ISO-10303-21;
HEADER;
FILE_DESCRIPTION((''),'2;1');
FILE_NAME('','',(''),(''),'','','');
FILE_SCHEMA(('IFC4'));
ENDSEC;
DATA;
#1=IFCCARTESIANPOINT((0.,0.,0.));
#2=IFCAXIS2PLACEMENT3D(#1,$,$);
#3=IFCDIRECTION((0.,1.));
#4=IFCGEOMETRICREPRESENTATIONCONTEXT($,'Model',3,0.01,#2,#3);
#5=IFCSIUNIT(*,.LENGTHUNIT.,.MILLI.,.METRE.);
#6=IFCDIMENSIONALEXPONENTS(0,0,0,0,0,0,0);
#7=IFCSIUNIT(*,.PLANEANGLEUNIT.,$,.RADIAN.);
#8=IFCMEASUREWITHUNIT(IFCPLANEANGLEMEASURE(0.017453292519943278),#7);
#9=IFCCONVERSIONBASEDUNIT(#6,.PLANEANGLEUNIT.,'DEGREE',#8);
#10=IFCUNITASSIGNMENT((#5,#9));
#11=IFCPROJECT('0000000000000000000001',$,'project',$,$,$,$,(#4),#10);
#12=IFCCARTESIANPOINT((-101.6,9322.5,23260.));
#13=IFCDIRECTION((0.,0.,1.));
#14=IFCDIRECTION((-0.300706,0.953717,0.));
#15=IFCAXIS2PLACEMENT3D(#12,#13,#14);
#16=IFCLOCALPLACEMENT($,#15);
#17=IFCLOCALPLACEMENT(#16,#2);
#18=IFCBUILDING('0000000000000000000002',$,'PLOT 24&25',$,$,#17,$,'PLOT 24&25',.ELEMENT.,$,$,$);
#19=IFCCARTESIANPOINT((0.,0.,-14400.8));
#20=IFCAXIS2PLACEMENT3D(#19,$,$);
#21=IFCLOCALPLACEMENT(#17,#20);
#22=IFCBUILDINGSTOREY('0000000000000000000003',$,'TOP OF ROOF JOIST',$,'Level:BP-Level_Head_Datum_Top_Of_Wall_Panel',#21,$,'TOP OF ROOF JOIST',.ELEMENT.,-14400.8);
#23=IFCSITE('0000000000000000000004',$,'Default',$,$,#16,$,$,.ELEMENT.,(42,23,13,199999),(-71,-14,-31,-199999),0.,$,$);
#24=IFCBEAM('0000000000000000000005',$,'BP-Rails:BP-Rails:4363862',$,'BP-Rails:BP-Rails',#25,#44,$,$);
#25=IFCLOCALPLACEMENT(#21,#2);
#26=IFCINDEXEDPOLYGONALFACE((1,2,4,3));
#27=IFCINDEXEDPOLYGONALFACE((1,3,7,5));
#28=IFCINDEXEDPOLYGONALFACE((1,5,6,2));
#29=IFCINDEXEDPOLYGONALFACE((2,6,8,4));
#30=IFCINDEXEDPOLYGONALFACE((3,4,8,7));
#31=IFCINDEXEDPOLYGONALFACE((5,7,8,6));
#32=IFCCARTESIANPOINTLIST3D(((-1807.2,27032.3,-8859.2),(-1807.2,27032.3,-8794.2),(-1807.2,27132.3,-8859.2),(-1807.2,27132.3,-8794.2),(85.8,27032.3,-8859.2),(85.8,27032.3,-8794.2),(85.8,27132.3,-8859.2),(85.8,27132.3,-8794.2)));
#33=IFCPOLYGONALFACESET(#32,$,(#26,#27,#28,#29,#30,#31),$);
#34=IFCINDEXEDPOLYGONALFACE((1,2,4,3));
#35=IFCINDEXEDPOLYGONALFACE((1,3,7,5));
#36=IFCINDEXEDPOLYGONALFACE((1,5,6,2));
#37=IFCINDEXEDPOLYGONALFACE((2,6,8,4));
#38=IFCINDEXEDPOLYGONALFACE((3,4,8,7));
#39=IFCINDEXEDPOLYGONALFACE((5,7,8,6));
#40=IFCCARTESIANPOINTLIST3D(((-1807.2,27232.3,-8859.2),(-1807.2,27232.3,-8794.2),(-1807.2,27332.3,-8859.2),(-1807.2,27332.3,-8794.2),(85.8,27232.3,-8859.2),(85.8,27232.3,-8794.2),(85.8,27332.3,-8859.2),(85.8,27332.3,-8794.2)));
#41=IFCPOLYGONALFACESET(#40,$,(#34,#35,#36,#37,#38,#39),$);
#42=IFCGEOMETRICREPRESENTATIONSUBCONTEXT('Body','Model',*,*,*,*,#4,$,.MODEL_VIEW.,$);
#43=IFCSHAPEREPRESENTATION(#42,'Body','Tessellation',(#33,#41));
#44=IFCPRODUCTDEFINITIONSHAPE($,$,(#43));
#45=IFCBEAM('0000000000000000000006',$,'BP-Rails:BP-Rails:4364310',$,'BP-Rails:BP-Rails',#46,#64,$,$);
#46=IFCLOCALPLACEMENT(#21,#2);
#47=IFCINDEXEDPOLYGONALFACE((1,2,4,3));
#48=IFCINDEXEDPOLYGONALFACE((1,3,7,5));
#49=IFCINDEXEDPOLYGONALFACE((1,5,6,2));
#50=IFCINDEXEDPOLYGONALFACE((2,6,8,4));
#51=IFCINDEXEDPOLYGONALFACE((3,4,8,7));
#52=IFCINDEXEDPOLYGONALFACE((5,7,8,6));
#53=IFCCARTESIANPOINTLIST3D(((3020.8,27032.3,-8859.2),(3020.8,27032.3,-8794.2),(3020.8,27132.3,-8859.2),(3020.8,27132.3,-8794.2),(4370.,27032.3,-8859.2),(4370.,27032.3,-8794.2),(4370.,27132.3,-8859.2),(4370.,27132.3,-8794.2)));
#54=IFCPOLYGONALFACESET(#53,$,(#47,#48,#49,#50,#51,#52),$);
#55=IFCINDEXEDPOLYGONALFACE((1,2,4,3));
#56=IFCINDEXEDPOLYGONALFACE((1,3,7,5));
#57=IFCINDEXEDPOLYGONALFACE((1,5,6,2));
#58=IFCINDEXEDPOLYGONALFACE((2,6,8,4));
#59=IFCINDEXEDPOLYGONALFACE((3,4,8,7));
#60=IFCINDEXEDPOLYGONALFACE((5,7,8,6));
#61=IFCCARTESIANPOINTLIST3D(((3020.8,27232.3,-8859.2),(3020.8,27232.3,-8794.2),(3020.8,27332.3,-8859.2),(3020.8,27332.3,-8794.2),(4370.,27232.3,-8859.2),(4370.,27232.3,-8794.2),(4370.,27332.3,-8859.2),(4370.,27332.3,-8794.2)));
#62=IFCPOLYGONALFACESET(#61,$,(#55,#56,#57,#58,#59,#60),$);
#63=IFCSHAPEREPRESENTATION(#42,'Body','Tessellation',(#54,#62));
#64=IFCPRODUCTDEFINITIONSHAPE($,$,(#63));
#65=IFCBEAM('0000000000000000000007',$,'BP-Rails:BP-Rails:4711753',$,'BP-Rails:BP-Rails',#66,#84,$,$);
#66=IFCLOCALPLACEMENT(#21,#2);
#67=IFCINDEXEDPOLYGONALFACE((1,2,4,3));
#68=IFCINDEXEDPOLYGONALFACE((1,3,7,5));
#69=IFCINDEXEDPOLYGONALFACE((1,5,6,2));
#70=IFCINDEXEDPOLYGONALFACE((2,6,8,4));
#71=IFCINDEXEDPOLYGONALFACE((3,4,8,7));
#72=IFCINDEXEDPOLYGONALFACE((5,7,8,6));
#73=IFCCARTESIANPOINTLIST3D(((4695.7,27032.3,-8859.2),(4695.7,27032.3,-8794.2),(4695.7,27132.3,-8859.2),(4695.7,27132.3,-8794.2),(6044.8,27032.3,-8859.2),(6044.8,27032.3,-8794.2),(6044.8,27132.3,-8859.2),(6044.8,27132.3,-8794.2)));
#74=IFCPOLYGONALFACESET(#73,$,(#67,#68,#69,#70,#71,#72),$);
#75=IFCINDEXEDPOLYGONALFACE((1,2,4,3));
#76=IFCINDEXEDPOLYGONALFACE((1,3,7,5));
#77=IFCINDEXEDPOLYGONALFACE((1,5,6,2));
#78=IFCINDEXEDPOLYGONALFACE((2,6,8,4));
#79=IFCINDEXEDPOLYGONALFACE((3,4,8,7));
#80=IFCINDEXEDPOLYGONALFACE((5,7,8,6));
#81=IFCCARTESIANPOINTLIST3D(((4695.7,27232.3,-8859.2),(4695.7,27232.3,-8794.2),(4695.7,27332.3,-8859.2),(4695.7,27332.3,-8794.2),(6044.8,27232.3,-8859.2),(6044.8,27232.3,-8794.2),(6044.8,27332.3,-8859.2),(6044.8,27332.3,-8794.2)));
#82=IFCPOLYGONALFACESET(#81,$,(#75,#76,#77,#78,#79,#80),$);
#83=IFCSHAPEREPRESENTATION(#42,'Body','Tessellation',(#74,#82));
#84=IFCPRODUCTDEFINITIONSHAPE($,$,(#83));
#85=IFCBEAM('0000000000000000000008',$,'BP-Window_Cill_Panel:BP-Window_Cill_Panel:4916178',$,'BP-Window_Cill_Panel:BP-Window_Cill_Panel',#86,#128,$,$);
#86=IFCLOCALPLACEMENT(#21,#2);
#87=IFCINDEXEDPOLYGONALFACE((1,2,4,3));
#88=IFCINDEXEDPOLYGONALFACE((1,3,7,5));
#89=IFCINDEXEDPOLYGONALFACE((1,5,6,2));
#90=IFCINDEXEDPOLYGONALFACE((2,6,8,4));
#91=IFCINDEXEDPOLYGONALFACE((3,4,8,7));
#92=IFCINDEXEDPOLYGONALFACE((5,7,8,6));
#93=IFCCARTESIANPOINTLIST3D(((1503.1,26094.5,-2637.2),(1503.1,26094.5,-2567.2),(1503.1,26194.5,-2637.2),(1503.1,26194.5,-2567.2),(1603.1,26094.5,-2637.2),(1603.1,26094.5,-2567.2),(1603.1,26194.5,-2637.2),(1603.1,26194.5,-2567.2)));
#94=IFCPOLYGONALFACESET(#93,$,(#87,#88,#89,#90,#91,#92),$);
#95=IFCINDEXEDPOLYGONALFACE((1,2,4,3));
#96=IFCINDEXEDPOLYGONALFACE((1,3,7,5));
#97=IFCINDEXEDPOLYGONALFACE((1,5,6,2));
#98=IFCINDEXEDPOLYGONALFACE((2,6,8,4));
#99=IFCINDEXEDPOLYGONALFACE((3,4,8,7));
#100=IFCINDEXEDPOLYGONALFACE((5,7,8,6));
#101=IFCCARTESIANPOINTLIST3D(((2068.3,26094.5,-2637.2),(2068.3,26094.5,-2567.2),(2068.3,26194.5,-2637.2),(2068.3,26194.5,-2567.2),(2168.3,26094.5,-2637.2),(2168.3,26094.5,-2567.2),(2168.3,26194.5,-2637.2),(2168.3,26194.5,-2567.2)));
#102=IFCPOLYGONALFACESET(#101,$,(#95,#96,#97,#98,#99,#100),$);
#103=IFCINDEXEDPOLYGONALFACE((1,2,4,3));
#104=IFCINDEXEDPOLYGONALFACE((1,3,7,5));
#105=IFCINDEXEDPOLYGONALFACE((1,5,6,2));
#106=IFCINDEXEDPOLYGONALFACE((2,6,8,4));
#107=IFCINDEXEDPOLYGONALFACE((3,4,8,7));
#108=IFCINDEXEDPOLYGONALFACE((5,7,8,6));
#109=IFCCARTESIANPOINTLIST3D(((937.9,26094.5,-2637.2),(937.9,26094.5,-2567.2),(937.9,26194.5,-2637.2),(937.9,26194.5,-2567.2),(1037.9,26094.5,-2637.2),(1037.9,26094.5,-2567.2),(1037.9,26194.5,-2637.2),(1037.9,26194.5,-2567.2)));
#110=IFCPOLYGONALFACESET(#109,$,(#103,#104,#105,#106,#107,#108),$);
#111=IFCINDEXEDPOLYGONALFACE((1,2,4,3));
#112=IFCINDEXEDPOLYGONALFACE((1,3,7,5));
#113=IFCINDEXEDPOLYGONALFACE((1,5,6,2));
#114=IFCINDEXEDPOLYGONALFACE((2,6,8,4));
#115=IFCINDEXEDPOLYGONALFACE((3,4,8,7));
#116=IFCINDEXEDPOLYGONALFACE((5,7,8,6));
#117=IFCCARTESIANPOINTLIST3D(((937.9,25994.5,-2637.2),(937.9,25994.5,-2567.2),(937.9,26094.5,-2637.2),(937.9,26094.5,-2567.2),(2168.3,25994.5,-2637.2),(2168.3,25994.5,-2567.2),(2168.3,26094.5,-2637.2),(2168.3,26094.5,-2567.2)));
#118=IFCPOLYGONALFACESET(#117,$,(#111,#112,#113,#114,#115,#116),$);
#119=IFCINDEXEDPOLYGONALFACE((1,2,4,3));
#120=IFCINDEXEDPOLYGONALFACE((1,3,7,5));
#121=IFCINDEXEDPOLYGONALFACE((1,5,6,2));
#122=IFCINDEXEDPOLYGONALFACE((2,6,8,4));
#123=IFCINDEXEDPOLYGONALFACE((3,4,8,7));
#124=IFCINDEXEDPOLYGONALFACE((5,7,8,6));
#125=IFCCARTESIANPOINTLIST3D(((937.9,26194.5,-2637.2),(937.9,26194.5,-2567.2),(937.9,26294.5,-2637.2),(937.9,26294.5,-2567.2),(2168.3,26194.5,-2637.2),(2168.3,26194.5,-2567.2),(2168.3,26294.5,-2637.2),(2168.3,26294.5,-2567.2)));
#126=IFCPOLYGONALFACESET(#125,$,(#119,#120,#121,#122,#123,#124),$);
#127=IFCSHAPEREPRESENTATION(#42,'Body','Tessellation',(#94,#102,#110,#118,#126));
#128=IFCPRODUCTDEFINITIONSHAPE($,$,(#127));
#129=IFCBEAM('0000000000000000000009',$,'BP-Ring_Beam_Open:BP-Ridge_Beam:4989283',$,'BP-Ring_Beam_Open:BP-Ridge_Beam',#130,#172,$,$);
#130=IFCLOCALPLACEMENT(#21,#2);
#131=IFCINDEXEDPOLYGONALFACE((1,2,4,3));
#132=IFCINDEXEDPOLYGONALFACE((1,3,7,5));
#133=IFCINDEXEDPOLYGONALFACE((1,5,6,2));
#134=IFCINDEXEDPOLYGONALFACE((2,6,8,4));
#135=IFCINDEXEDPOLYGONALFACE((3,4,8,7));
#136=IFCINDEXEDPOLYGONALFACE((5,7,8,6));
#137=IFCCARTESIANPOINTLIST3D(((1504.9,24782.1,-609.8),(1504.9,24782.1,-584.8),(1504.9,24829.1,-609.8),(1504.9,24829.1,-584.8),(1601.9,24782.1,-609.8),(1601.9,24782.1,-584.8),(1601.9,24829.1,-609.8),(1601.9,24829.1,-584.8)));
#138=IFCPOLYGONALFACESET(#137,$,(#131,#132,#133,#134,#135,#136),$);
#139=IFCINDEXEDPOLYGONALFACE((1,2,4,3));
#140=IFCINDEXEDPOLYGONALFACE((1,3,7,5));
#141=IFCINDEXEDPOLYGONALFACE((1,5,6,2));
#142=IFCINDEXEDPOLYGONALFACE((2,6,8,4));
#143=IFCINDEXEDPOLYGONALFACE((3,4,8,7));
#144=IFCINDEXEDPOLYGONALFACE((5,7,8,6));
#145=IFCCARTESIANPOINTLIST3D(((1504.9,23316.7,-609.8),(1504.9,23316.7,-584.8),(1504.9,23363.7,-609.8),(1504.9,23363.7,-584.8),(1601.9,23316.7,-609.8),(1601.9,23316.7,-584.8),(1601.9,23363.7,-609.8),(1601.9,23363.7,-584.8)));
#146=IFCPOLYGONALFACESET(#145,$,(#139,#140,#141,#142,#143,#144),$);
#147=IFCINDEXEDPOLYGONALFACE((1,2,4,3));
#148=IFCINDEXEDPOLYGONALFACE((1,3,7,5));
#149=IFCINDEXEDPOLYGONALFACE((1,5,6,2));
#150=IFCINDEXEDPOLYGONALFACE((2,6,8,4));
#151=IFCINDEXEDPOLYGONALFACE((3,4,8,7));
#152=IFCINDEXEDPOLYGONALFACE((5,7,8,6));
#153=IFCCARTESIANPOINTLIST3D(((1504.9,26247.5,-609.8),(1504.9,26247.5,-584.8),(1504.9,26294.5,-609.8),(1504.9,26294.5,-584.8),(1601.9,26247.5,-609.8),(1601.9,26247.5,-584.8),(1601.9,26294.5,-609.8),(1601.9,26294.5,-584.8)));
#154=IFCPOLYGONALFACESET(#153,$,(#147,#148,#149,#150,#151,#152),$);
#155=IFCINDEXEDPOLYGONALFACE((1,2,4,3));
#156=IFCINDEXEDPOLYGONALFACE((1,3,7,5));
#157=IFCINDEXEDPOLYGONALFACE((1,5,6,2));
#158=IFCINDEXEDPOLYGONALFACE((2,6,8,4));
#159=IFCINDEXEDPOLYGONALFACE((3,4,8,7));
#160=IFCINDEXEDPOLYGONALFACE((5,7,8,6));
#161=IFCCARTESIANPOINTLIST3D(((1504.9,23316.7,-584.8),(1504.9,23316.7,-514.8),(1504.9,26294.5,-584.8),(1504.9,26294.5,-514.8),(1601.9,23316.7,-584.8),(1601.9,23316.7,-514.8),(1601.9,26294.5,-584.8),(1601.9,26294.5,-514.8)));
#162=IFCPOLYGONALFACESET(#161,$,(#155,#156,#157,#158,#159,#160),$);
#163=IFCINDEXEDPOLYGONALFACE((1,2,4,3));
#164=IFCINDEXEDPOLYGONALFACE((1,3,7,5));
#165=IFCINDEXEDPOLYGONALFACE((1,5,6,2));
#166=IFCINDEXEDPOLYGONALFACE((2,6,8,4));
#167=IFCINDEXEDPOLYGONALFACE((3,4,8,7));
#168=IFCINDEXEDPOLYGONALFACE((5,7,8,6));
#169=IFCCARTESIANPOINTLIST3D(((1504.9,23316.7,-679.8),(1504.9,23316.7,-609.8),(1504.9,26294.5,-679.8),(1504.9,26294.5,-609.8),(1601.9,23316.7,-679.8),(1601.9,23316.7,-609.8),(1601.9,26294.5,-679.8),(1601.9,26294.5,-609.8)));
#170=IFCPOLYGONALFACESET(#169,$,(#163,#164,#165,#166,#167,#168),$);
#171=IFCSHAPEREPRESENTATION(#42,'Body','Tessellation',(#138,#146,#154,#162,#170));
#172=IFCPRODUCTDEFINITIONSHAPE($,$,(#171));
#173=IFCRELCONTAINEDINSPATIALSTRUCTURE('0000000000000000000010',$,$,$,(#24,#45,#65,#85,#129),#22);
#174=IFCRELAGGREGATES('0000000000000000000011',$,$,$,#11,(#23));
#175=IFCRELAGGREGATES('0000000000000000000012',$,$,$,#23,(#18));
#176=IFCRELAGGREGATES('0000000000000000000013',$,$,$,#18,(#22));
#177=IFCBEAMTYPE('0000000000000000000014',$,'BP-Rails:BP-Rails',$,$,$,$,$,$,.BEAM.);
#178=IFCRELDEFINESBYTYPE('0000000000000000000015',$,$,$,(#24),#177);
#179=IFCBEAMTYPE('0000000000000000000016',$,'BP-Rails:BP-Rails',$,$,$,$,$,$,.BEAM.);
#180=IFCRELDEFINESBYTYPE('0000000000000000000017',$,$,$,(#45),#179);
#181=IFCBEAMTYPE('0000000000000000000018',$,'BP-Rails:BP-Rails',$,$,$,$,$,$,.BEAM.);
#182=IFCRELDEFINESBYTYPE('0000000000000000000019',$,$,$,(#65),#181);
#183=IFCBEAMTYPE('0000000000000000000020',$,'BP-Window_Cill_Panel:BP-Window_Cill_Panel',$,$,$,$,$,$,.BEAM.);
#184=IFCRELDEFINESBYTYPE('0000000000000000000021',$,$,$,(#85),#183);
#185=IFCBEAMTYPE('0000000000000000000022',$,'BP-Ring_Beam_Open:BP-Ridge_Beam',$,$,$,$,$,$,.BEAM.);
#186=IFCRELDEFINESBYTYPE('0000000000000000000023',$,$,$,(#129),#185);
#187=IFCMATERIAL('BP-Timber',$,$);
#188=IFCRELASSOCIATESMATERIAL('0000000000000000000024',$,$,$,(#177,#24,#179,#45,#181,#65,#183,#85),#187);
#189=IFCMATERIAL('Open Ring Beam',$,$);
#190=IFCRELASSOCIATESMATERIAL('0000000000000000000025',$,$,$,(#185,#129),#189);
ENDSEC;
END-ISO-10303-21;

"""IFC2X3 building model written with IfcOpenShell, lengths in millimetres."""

from ifc_helpers import new_model, entity, si_unit, converted_unit, direction, frame, frame_2d, origin, origin_2d_with_axis, place, context, subcontext, project, spatial, rectangle, extrude, source, transform, mapped, material, type_object, type_shapes, element, save


model = new_model("IFC2X3")

# Units and contexts
model_context = context("Model", 3, precision=0.01, world=origin(), true_north=direction((0.0, 1.0)))
body_context = subcontext(model_context, "Body", "Model", "MODEL_VIEW")
ifc_project = project(units=[si_unit("LENGTHUNIT", "METRE", prefix="MILLI"), converted_unit("PLANEANGLEUNIT", "DEGREE", entity("IfcPlaneAngleMeasure", 0.017453292519943278), si_unit("PLANEANGLEUNIT", "RADIAN"), dimensions=[0, 0, 0, 0, 0, 0, 0])], contexts=[model_context])

# Site, building, storey
site_placement = place(None, frame((-101.6, 9322.5, 23260.0), z_axis=(0.0, 0.0, 1.0), x_axis=(-0.300706, 0.953717, 0.0)))
site = spatial("IfcSite", under=ifc_project, at=site_placement, Name="Default", CompositionType="ELEMENT", RefLatitude=(42, 23, 13, 199999), RefLongitude=(-71, -14, -31, -199999), RefElevation=0.0)
building_placement = place(site_placement, origin())
building = spatial("IfcBuilding", under=site, at=building_placement, Name="PLOT 24&25", LongName="PLOT 24&25", CompositionType="ELEMENT")
storey_placement = place(building_placement, frame((0.0, 0.0, -14400.8)))
storey = spatial("IfcBuildingStorey", under=building, at=storey_placement, Name="TOP OF ROOF JOIST", ObjectType="Level:BP-Level_Head_Datum_Top_Of_Wall_Panel", LongName="TOP OF ROOF JOIST", CompositionType="ELEMENT", Elevation=-14400.8)

# Beams
ifc_material_1 = material(Name="BP-Timber")
beam_type_1 = type_object("IfcBeamType", Name="BP-Rails:BP-Rails", PredefinedType="BEAM", material=ifc_material_1)
shared_shape_1 = source(origin(), body_context, "Body", "SweptSolid", [
    extrude(rectangle(XDim=65.0, YDim=100.0, at=frame_2d((0.0, 0.0), x_axis=(1.0, 0.0))), frame((-946.5, -100.0, -32.5), z_axis=(1.0, 0.0, 0.0), x_axis=(0.0, 0.0, -1.0)), (0.0, 0.0, 1.0), 1893.0),
    extrude(rectangle(XDim=65.0, YDim=100.0, at=origin_2d_with_axis()), frame((-946.5, 100.0, -32.5), z_axis=(1.0, 0.0, 0.0), x_axis=(0.0, 0.0, -1.0)), (0.0, 0.0, 1.0), 1893.0),
])
type_shapes(beam_type_1, [shared_shape_1])
beam_1_placement = place(storey_placement, frame((-860.7, 27182.3, -8794.2)))
element("IfcBeam", 1, at=beam_1_placement, inside=storey, type_object=beam_type_1, material=ifc_material_1, Name="BP-Rails:BP-Rails:4363862", ObjectType="BP-Rails:BP-Rails", context=body_context, shape_type="MappedRepresentation", body=[
    mapped(shared_shape_1, transform((0.0, 0.0, 0.0), scale=1.0)),
])
beam_type_2 = type_object("IfcBeamType", Name="BP-Rails:BP-Rails", PredefinedType="BEAM", material=ifc_material_1)
shared_shape_2 = source(origin(), body_context, "Body", "SweptSolid", [
    extrude(rectangle(XDim=65.0, YDim=100.0, at=frame_2d((0.0, 0.0), x_axis=(1.0, 0.0))), frame((-674.6, -100.0, -32.5), z_axis=(1.0, 0.0, 0.0), x_axis=(0.0, 0.0, -1.0)), (0.0, 0.0, 1.0), 1349.2),
    extrude(rectangle(XDim=65.0, YDim=100.0, at=origin_2d_with_axis()), frame((-674.6, 100.0, -32.5), z_axis=(1.0, 0.0, 0.0), x_axis=(0.0, 0.0, -1.0)), (0.0, 0.0, 1.0), 1349.2),
])
type_shapes(beam_type_2, [shared_shape_2])
beam_2_placement = place(storey_placement, frame((3695.4, 27182.3, -8794.2)))
element("IfcBeam", 2, at=beam_2_placement, inside=storey, type_object=beam_type_2, material=ifc_material_1, Name="BP-Rails:BP-Rails:4364310", ObjectType="BP-Rails:BP-Rails", context=body_context, shape_type="MappedRepresentation", body=[
    mapped(shared_shape_2, transform((0.0, 0.0, 0.0), scale=1.0)),
])
beam_type_3 = type_object("IfcBeamType", Name="BP-Rails:BP-Rails", PredefinedType="BEAM", material=ifc_material_1)
shared_shape_3 = source(origin(), body_context, "Body", "SweptSolid", [
    extrude(rectangle(XDim=65.0, YDim=100.0, at=frame_2d((0.0, 0.0), x_axis=(1.0, 0.0))), frame((-674.6, 100.0, -32.5), z_axis=(1.0, 0.0, 0.0), x_axis=(0.0, 0.0, -1.0)), (0.0, 0.0, 1.0), 1349.2),
    extrude(rectangle(XDim=65.0, YDim=100.0, at=origin_2d_with_axis()), frame((-674.6, -100.0, -32.5), z_axis=(1.0, 0.0, 0.0), x_axis=(0.0, 0.0, -1.0)), (0.0, 0.0, 1.0), 1349.2),
])
type_shapes(beam_type_3, [shared_shape_3])
beam_3_placement = place(storey_placement, frame((5370.3, 27182.3, -8794.2), z_axis=(0.0, 0.0, 1.0), x_axis=(-1.0, 0.0, 0.0)))
element("IfcBeam", 3, at=beam_3_placement, inside=storey, type_object=beam_type_3, material=ifc_material_1, Name="BP-Rails:BP-Rails:4711753", ObjectType="BP-Rails:BP-Rails", context=body_context, shape_type="MappedRepresentation", body=[
    mapped(shared_shape_3, transform((0.0, 0.0, 0.0), scale=1.0)),
])
beam_type_4 = type_object("IfcBeamType", Name="BP-Window_Cill_Panel:BP-Window_Cill_Panel", PredefinedType="BEAM", material=ifc_material_1)
shared_shape_4 = source(origin(), body_context, "Body", "SweptSolid", [
    extrude(rectangle(XDim=70.0, YDim=100.0, at=frame_2d((0.0, 0.0), x_axis=(1.0, 0.0))), frame((-50.0, 0.0, -35.0), z_axis=(1.0, 0.0, 0.0), x_axis=(0.0, 0.0, -1.0)), (0.0, 0.0, 1.0), 100.0),
    extrude(rectangle(XDim=70.0, YDim=100.0, at=frame_2d((0.0, 0.0), x_axis=(1.0, 0.0))), frame((515.2, 0.0, -35.0), z_axis=(1.0, 0.0, 0.0), x_axis=(0.0, 0.0, -1.0)), (0.0, 0.0, 1.0), 100.0),
    extrude(rectangle(XDim=70.0, YDim=100.0, at=frame_2d((0.0, 0.0), x_axis=(1.0, 0.0))), frame((-615.2, 0.0, -35.0), z_axis=(1.0, 0.0, 0.0), x_axis=(0.0, 0.0, -1.0)), (0.0, 0.0, 1.0), 100.0),
    extrude(rectangle(XDim=70.0, YDim=100.0, at=frame_2d((0.0, 0.0), x_axis=(1.0, 0.0))), frame((-615.2, -100.0, -35.0), z_axis=(1.0, 0.0, 0.0), x_axis=(0.0, 0.0, -1.0)), (0.0, 0.0, 1.0), 1230.4),
    extrude(rectangle(XDim=70.0, YDim=100.0, at=origin_2d_with_axis()), frame((-615.2, 100.0, -35.0), z_axis=(1.0, 0.0, 0.0), x_axis=(0.0, 0.0, -1.0)), (0.0, 0.0, 1.0), 1230.4),
])
type_shapes(beam_type_4, [shared_shape_4])
beam_4_placement = place(storey_placement, frame((1553.1, 26144.5, -2567.2)))
element("IfcBeam", 4, at=beam_4_placement, inside=storey, type_object=beam_type_4, material=ifc_material_1, Name="BP-Window_Cill_Panel:BP-Window_Cill_Panel:4916178", ObjectType="BP-Window_Cill_Panel:BP-Window_Cill_Panel", context=body_context, shape_type="MappedRepresentation", body=[
    mapped(shared_shape_4, transform((0.0, 0.0, 0.0), scale=1.0)),
])
ifc_material_2 = material(Name="Open Ring Beam")
beam_type_5 = type_object("IfcBeamType", Name="BP-Ring_Beam_Open:BP-Ridge_Beam", PredefinedType="BEAM", material=ifc_material_2)
shared_shape_5 = source(origin(), body_context, "Body", "SweptSolid", [
    extrude(rectangle(XDim=25.0, YDim=97.0, at=frame_2d((0.0, 0.0), x_axis=(1.0, 0.0))), frame((-23.5, 0.0, -82.5), z_axis=(1.0, 0.0, 0.0), x_axis=(0.0, 0.0, -1.0)), (0.0, 0.0, 1.0), 47.0),
    extrude(rectangle(XDim=25.0, YDim=97.0, at=frame_2d((0.0, 0.0), x_axis=(1.0, 0.0))), frame((1441.9, 0.0, -82.5), z_axis=(1.0, 0.0, 0.0), x_axis=(0.0, 0.0, -1.0)), (0.0, 0.0, 1.0), 47.0),
    extrude(rectangle(XDim=25.0, YDim=97.0, at=frame_2d((0.0, 0.0), x_axis=(1.0, 0.0))), frame((-1488.9, 0.0, -82.5), z_axis=(1.0, 0.0, 0.0), x_axis=(0.0, 0.0, -1.0)), (0.0, 0.0, 1.0), 47.0),
    extrude(rectangle(XDim=70.0, YDim=97.0, at=origin_2d_with_axis()), frame((-1488.9, 0.0, -35.0), z_axis=(1.0, 0.0, 0.0), x_axis=(0.0, 0.0, -1.0)), (0.0, 0.0, 1.0), 2977.9),
    extrude(rectangle(XDim=70.0, YDim=97.0, at=origin_2d_with_axis()), frame((-1488.9, 0.0, -130.0), z_axis=(1.0, 0.0, 0.0), x_axis=(0.0, 0.0, -1.0)), (0.0, 0.0, 1.0), 2977.9),
])
type_shapes(beam_type_5, [shared_shape_5])
beam_5_placement = place(storey_placement, frame((1553.4, 24805.6, -514.8), z_axis=(0.0, 0.0, 1.0), x_axis=(0.0, -1.0, 0.0)))
element("IfcBeam", 5, at=beam_5_placement, inside=storey, type_object=beam_type_5, material=ifc_material_2, Name="BP-Ring_Beam_Open:BP-Ridge_Beam:4989283", ObjectType="BP-Ring_Beam_Open:BP-Ridge_Beam", context=body_context, shape_type="MappedRepresentation", body=[
    mapped(shared_shape_5, transform((0.0, 0.0, 0.0), scale=1.0)),
])

save(model, "model.ifc")
